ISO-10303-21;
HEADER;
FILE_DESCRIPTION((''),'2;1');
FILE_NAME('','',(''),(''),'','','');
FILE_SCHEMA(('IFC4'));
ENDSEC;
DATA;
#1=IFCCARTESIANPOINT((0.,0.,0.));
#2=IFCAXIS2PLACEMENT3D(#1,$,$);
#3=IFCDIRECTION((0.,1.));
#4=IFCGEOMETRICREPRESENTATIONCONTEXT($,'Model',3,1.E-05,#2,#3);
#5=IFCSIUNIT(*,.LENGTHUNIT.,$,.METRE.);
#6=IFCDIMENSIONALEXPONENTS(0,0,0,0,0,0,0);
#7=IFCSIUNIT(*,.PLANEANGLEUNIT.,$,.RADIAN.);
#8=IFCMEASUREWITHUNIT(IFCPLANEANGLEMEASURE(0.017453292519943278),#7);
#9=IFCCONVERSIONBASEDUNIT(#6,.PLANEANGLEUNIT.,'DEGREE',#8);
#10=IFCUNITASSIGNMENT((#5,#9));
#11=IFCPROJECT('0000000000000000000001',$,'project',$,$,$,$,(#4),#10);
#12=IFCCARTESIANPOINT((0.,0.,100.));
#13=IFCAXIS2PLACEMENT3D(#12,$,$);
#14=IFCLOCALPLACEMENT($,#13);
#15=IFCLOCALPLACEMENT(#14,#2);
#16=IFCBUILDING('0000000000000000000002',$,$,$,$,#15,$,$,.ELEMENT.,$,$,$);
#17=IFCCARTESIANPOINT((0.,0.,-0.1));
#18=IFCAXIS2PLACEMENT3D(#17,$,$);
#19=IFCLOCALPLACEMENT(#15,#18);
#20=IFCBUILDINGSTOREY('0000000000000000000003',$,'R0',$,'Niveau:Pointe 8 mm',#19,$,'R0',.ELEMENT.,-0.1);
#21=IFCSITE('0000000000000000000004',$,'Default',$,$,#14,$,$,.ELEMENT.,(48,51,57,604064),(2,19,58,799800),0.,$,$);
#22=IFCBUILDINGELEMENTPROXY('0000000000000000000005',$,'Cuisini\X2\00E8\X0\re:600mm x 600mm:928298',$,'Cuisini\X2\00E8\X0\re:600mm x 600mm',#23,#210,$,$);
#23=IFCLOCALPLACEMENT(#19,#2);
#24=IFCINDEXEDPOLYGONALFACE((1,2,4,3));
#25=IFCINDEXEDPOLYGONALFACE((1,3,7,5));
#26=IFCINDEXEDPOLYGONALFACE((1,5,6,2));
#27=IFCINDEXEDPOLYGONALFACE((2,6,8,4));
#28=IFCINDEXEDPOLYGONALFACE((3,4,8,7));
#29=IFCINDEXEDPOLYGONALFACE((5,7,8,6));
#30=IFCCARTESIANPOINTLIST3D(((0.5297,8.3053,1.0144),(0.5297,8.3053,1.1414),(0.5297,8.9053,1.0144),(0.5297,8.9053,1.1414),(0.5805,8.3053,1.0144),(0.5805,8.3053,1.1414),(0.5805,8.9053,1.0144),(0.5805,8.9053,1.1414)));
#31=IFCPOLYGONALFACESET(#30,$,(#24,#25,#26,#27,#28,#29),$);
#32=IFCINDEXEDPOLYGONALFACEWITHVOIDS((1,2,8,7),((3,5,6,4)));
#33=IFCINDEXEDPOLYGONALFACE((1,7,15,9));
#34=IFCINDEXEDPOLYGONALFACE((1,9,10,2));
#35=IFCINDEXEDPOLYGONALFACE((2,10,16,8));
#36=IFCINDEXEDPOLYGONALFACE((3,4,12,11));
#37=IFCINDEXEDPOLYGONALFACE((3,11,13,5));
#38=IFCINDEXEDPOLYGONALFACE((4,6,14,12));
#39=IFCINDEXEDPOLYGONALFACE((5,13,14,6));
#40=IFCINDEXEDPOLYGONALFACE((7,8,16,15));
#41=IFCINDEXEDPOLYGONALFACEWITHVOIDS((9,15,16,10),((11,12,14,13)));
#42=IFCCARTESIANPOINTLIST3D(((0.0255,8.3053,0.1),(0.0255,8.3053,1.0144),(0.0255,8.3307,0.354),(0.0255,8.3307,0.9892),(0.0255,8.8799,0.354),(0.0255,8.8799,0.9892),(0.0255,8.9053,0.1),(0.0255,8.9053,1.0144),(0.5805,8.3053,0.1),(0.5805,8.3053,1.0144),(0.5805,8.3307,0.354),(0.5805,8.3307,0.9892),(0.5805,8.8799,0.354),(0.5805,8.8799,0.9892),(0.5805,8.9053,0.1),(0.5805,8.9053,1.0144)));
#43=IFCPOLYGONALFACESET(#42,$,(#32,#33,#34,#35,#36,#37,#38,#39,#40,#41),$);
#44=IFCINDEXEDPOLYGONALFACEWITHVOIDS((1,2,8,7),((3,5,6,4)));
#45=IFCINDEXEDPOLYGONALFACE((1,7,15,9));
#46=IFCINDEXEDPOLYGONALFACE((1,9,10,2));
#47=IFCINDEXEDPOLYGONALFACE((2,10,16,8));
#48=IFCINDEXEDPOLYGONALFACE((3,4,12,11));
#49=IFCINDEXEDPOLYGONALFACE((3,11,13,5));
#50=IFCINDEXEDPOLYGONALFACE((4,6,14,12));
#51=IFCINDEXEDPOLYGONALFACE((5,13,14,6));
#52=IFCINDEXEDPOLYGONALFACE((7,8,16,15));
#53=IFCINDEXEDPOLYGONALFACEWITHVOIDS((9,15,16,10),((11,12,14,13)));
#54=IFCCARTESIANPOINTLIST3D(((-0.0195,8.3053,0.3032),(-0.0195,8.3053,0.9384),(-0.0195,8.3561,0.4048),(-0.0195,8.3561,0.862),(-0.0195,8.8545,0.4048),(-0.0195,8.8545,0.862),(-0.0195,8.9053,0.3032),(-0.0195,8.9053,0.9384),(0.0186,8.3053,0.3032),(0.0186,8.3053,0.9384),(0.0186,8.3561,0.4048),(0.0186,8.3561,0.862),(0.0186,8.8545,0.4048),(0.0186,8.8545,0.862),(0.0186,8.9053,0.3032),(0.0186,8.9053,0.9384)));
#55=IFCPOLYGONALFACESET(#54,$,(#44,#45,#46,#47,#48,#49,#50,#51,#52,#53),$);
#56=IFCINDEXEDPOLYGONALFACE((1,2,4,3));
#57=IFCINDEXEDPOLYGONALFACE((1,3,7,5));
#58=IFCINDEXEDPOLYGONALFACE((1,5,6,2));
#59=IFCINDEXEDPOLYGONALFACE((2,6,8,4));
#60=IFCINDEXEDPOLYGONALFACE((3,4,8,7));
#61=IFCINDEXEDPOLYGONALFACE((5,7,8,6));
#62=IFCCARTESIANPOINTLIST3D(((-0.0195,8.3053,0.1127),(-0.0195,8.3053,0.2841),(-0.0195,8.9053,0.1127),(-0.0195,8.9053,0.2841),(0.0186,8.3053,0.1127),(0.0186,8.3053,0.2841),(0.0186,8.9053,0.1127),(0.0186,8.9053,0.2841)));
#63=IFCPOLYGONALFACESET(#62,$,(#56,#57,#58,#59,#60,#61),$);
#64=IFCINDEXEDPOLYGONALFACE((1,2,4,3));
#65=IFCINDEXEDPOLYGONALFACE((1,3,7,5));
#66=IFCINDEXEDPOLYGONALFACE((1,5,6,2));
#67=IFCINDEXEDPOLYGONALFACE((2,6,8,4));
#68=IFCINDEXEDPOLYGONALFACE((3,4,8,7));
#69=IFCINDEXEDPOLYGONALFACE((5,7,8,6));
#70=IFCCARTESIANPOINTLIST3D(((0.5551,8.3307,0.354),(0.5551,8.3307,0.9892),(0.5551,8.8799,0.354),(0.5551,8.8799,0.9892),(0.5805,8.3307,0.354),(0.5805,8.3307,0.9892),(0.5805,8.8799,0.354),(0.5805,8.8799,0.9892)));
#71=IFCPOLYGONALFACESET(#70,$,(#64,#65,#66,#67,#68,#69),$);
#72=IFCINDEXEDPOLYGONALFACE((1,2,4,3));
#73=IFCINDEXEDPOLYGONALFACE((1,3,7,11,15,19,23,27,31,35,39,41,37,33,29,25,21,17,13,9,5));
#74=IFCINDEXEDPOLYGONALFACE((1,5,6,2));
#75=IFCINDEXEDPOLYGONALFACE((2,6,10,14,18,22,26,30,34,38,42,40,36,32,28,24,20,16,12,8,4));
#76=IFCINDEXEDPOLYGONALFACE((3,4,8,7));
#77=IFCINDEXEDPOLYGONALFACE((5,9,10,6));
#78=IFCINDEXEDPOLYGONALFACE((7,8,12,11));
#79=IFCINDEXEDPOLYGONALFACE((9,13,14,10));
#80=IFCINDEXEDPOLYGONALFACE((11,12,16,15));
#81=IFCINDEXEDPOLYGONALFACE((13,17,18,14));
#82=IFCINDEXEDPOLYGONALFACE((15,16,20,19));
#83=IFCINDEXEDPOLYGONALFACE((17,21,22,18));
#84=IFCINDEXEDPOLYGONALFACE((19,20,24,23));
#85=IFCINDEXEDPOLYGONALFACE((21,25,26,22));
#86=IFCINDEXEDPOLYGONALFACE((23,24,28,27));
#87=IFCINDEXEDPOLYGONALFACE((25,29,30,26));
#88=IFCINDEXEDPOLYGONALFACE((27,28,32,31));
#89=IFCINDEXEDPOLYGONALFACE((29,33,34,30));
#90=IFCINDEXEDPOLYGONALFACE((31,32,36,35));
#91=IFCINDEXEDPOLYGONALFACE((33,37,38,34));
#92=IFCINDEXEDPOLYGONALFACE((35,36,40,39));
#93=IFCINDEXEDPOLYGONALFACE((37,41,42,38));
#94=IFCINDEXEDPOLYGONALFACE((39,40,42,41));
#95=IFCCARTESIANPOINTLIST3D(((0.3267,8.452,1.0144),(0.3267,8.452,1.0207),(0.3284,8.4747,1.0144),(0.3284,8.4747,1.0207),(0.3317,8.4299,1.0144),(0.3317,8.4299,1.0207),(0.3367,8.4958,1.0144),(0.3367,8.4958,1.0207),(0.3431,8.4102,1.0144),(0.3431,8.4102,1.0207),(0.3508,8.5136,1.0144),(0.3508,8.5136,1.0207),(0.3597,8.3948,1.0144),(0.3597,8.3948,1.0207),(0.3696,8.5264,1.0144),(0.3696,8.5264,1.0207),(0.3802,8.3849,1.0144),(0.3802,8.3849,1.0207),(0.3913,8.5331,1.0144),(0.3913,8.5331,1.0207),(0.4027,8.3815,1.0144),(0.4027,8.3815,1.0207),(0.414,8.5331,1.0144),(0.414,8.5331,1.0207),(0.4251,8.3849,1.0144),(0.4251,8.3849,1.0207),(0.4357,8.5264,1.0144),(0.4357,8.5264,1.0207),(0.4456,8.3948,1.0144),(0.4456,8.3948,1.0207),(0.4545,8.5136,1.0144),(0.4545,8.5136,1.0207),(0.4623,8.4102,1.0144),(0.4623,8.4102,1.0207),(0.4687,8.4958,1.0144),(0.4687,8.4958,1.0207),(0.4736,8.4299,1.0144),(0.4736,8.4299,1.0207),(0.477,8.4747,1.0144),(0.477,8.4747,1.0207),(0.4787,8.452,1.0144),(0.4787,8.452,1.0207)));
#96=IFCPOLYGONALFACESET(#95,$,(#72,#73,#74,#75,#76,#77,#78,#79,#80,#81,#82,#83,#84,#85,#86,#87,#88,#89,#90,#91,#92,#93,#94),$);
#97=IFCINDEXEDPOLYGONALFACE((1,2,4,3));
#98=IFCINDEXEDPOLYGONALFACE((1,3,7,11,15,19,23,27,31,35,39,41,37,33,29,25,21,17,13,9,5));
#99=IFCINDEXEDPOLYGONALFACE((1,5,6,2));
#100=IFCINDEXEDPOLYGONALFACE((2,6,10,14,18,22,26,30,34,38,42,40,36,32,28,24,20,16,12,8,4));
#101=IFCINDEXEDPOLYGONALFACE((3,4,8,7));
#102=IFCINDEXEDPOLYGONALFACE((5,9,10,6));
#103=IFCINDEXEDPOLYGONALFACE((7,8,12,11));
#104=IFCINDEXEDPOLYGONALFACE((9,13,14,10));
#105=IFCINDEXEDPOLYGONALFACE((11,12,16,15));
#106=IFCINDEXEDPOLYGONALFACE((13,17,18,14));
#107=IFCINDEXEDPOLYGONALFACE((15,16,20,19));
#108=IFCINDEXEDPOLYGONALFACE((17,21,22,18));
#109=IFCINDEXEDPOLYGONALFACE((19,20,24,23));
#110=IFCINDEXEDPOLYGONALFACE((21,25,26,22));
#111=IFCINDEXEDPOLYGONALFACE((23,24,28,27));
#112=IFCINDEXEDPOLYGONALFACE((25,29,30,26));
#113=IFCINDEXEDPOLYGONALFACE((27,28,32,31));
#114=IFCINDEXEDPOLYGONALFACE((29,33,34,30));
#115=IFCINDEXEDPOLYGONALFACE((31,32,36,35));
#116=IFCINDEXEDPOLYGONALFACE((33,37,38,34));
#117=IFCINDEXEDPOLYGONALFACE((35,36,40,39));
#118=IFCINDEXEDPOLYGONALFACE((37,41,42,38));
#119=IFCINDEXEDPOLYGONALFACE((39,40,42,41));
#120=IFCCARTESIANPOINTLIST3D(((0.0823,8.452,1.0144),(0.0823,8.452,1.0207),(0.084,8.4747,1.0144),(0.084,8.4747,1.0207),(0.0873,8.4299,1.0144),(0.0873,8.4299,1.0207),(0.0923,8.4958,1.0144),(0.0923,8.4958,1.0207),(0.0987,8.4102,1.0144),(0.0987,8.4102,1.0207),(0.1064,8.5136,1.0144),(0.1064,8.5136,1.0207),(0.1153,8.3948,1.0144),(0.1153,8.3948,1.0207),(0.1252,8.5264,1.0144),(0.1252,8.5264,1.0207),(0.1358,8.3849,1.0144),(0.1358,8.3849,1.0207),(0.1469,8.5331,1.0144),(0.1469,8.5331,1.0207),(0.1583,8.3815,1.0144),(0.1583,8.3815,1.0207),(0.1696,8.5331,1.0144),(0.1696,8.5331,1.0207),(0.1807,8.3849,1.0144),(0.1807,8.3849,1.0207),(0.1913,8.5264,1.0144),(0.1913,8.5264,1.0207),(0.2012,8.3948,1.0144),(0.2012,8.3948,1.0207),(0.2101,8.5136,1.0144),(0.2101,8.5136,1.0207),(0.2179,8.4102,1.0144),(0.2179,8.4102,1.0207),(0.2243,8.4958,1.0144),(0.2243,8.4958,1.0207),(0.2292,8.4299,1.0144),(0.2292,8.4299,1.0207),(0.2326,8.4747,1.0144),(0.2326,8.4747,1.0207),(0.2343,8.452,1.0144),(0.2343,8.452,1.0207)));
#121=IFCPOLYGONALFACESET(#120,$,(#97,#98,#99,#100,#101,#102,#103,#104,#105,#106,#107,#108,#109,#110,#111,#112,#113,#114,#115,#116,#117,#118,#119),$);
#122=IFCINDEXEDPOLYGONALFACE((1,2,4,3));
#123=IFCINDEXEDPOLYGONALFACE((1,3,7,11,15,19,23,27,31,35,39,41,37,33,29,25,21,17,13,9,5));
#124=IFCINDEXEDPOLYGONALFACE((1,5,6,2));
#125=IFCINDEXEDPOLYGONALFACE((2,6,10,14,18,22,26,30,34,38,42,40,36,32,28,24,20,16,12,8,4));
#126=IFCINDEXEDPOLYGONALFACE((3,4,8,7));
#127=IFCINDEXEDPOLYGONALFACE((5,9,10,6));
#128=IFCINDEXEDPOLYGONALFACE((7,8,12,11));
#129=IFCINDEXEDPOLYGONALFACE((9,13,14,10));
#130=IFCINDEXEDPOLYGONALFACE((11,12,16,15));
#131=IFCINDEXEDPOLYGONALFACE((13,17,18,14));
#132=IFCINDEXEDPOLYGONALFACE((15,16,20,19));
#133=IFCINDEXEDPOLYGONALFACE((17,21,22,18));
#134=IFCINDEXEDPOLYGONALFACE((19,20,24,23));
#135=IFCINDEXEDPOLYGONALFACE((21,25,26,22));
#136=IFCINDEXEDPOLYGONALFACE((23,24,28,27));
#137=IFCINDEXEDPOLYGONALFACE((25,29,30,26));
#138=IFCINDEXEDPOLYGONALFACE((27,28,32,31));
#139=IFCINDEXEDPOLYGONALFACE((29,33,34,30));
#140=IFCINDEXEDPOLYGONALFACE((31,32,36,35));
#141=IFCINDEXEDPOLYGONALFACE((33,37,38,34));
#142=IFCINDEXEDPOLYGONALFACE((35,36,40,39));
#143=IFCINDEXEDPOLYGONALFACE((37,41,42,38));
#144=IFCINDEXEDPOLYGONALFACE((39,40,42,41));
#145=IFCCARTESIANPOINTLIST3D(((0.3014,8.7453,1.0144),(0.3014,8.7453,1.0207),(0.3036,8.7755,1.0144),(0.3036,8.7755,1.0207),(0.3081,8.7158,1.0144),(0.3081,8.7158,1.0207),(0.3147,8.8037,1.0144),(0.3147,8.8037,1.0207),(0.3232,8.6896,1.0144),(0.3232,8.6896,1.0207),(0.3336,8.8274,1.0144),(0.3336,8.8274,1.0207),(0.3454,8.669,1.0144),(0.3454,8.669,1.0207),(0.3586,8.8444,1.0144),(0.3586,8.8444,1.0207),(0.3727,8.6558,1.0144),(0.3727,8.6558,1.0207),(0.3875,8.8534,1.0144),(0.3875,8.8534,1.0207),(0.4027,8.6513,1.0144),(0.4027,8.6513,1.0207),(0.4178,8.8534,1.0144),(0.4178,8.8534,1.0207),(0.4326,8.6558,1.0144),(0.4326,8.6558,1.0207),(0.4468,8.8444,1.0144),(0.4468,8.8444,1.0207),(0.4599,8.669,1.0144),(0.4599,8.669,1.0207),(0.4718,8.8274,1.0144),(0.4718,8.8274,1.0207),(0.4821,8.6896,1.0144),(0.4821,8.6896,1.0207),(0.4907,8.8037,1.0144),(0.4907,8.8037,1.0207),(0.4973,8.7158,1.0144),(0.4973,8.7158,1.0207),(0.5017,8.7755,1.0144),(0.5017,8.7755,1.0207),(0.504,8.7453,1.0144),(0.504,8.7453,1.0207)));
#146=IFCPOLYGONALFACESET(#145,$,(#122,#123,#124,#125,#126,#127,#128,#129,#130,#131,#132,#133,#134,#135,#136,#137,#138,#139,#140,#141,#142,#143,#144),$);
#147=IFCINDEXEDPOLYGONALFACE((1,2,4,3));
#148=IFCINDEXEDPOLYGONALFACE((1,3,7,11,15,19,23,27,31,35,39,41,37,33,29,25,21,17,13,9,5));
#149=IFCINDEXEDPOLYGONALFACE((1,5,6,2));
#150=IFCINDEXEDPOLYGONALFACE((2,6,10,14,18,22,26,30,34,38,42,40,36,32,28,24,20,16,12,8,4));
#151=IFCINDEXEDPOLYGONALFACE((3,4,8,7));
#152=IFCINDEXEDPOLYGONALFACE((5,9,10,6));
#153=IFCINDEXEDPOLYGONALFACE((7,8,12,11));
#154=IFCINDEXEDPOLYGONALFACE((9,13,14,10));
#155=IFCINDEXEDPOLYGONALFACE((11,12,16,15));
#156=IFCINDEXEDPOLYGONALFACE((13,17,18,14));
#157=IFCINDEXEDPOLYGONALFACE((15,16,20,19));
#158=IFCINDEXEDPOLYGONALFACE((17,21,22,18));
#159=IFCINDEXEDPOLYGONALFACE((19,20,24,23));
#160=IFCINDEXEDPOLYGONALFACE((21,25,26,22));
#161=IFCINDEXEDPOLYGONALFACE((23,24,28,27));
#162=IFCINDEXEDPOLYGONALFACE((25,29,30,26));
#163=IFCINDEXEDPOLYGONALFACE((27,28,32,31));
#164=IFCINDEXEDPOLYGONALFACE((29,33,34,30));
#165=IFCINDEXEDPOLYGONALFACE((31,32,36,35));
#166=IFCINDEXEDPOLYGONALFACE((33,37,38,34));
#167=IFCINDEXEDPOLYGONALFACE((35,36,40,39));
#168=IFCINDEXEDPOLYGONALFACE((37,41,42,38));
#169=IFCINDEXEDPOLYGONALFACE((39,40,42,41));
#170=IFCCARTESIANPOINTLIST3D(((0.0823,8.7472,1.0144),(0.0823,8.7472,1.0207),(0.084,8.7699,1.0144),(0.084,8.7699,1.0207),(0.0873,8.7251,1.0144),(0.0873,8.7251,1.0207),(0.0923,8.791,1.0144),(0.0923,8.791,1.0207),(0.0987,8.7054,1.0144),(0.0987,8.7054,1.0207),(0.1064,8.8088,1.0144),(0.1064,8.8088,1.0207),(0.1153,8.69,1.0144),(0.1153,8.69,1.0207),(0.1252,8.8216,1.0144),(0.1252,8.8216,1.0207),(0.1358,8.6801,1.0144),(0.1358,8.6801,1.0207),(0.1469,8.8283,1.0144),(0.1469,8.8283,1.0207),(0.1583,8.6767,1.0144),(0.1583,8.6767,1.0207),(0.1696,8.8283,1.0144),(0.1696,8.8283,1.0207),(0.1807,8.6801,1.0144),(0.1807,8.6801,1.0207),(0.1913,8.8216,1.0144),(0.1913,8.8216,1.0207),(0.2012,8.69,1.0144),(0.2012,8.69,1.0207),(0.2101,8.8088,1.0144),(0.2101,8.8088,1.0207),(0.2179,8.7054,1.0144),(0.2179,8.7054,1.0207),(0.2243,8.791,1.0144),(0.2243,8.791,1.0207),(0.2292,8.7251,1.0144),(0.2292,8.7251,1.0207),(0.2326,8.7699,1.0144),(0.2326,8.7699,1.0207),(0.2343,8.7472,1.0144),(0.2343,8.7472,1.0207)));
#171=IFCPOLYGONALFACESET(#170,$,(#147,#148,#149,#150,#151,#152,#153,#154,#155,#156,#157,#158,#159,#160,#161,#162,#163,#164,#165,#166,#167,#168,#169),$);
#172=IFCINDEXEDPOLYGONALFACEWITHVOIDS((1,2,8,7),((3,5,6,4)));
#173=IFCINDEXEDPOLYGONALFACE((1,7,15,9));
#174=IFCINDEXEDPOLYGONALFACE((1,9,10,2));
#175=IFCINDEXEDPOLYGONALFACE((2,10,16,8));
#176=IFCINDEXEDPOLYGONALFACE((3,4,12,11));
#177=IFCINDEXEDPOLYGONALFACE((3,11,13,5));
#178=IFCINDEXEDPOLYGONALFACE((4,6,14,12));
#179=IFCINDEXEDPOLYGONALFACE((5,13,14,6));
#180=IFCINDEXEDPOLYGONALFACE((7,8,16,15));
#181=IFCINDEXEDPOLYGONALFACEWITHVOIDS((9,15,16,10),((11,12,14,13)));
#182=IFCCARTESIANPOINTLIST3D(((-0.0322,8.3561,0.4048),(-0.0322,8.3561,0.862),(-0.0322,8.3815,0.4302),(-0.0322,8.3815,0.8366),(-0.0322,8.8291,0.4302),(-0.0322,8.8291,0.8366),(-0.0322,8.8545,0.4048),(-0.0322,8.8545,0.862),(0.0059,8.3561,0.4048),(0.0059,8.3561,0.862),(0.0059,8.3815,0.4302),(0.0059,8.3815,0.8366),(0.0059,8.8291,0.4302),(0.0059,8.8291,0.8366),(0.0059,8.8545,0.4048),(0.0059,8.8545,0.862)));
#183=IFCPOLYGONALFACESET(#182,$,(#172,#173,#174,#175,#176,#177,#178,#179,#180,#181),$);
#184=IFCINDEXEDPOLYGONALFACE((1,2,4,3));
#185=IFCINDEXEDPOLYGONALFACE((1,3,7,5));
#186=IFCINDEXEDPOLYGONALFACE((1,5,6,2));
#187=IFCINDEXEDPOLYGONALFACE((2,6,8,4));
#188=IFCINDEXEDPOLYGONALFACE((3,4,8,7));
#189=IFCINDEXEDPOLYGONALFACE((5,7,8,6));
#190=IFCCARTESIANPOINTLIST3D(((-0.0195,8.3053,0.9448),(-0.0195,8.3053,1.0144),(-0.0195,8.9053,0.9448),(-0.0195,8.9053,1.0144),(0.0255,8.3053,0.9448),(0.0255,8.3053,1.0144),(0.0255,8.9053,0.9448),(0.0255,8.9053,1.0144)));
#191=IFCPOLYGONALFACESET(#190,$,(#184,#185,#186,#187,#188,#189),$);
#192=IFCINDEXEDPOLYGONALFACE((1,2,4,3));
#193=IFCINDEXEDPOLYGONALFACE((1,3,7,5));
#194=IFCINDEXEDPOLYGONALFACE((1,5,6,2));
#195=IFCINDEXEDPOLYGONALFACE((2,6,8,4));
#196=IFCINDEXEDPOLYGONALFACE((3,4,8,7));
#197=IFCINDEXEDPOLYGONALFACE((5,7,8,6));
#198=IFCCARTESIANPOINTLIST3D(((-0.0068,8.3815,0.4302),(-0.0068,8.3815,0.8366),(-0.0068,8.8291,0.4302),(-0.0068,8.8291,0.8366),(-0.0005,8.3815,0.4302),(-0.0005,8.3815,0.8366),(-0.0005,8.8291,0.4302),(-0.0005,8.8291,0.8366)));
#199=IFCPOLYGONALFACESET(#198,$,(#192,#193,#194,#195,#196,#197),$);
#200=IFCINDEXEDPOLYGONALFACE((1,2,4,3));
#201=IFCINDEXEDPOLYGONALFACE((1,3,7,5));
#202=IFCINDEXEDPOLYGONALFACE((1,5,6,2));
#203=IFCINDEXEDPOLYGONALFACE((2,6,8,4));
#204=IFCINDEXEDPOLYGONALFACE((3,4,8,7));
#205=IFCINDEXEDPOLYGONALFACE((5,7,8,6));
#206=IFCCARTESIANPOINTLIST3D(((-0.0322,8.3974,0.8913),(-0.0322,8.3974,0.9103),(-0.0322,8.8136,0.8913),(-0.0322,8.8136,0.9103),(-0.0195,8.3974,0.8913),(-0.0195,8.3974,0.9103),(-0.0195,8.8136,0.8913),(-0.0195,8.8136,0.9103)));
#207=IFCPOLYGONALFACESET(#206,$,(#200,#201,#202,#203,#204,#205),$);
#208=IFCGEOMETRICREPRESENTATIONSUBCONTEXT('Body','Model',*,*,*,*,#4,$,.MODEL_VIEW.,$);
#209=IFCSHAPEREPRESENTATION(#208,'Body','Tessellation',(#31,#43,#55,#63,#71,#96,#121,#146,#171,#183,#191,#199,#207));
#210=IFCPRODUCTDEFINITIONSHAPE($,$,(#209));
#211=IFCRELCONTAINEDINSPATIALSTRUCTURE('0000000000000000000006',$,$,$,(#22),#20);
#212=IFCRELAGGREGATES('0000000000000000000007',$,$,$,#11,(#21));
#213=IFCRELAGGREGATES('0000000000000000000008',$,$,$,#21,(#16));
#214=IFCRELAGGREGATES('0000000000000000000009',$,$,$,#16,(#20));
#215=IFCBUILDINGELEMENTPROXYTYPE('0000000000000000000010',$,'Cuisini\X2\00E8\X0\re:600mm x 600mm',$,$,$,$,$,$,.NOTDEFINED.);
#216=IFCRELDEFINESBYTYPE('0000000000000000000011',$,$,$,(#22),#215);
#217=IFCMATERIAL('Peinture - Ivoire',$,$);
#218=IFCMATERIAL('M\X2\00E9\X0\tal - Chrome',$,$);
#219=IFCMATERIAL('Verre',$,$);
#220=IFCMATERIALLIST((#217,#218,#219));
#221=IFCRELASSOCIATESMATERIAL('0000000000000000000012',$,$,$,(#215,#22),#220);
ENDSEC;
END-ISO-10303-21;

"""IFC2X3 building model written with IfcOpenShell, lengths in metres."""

from ifc_helpers import new_model, entity, si_unit, converted_unit, direction, frame, frame_2d, origin, origin_2d_with_axis, place, context, subcontext, project, spatial, polyline, rectangle, circle, outline, extrude, source, transform, mapped, material, material_list, type_object, type_shapes, element, save


model = new_model("IFC2X3")

# Units and contexts
model_context = context("Model", 3, precision=1e-05, world=origin(), true_north=direction((0.0, 1.0)))
body_context = subcontext(model_context, "Body", "Model", "MODEL_VIEW")
ifc_project = project(units=[si_unit("LENGTHUNIT", "METRE"), converted_unit("PLANEANGLEUNIT", "DEGREE", entity("IfcPlaneAngleMeasure", 0.017453292519943278), si_unit("PLANEANGLEUNIT", "RADIAN"), dimensions=[0, 0, 0, 0, 0, 0, 0])], contexts=[model_context])

# Site, building, storey
site_placement = place(None, frame((0.0, 0.0, 100.0)))
site = spatial("IfcSite", under=ifc_project, at=site_placement, Name="Default", CompositionType="ELEMENT", RefLatitude=(48, 51, 57, 604064), RefLongitude=(2, 19, 58, 799800), RefElevation=0.0)
building_placement = place(site_placement, origin())
building = spatial("IfcBuilding", under=site, at=building_placement, CompositionType="ELEMENT")
storey_placement = place(building_placement, frame((0.0, 0.0, -0.1)))
storey = spatial("IfcBuildingStorey", under=building, at=storey_placement, Name="R0", ObjectType="Niveau:Pointe 8 mm", LongName="R0", CompositionType="ELEMENT", Elevation=-0.1)

# Building element proxy
ifc_material_1 = material(Name="Peinture - Ivoire")
ifc_material_2 = material(Name="Métal - Chrome")
ifc_material_3 = material(Name="Verre")
ifc_material_list_1 = material_list([ifc_material_1, ifc_material_2, ifc_material_3])
building_element_proxy_type = type_object("IfcBuildingElementProxyType", Name="Cuisinière:600mm x 600mm", PredefinedType="NOTDEFINED", material=ifc_material_list_1)
shared_shape_1 = source(origin(), body_context, "Body", "SweptSolid", [
    extrude(rectangle(XDim=0.6, YDim=0.0508, at=origin_2d_with_axis()), frame((0.3, 0.5746, 0.9144), z_axis=(0.0, 0.0, 1.0), x_axis=(-1.0, 0.0, 0.0)), (0.0, 0.0, 1.0), 0.127),
    extrude(outline(polyline([(-0.4572, -0.3), (0.4572, -0.3), (0.4572, 0.3), (-0.4572, 0.3), (-0.4572, -0.3)]), holes=[polyline([(-0.432, -0.2746), (-0.432, 0.2746), (0.2032, 0.2746), (0.2032, -0.2746), (-0.432, -0.2746)])]), frame((0.3, 0.045, 0.4572), z_axis=(0.0, 1.0, 0.0), x_axis=(0.0, 0.0, -1.0)), (0.0, 0.0, 1.0), 0.555),
    extrude(outline(polyline([(-0.3176, -0.3), (0.3176, -0.3), (0.3176, 0.3), (-0.3176, 0.3), (-0.3176, -0.3)]), holes=[polyline([(-0.2412, -0.2492), (-0.2412, 0.2492), (0.216, 0.2492), (0.216, -0.2492), (-0.2412, -0.2492)])]), frame((0.3, 0.0, 0.5208), z_axis=(0.0, 1.0, 0.0), x_axis=(0.0, 0.0, -1.0)), (0.0, 0.0, 1.0), 0.0381),
    extrude(rectangle(XDim=0.0381, YDim=0.6, at=origin_2d_with_axis()), frame((0.3, 0.0191, 0.0127), z_axis=(0.0, 0.0, 1.0), x_axis=(0.0, 1.0, 0.0)), (0.0, 0.0, 1.0), 0.1715),
    extrude(rectangle(XDim=0.0254, YDim=0.5492, at=frame_2d((0.0, 0.0), x_axis=(1.0, 0.0))), frame((0.3, 0.5873, 0.254), z_axis=(0.0, 0.0, 1.0), x_axis=(0.0, -1.0, 0.0)), (0.0, 0.0, 1.0), 0.6352),
    extrude(circle(Radius=0.0762, at=frame_2d((0.0, 0.0), x_axis=(1.0, 0.0))), frame((0.4476, 0.4222, 0.9144)), (0.0, 0.0, 1.0), 0.0064),
    extrude(circle(Radius=0.0762, at=frame_2d((0.0, 0.0), x_axis=(1.0, 0.0))), frame((0.4476, 0.1778, 0.9144)), (0.0, 0.0, 1.0), 0.0064),
    extrude(circle(Radius=0.1016, at=frame_2d((0.0, 0.0), x_axis=(1.0, 0.0))), frame((0.1524, 0.4222, 0.9144)), (0.0, 0.0, 1.0), 0.0064),
    extrude(circle(Radius=0.0762, at=frame_2d((0.0, 0.0), x_axis=(1.0, 0.0))), frame((0.1524, 0.1778, 0.9144)), (0.0, 0.0, 1.0), 0.0064),
    extrude(outline(polyline([(-0.2286, -0.2492), (0.2286, -0.2492), (0.2286, 0.2492), (-0.2286, 0.2492), (-0.2286, -0.2492)]), holes=[polyline([(-0.2032, -0.2238), (-0.2032, 0.2238), (0.2032, 0.2238), (0.2032, -0.2238), (-0.2032, -0.2238)])]), frame((0.3, -0.0127, 0.5334), z_axis=(0.0, 1.0, 0.0), x_axis=(0.0, 0.0, -1.0)), (0.0, 0.0, 1.0), 0.0381),
    extrude(rectangle(XDim=0.045, YDim=0.6, at=origin_2d_with_axis()), frame((0.3, 0.0225, 0.8448), z_axis=(0.0, 0.0, 1.0), x_axis=(0.0, 1.0, 0.0)), (0.0, 0.0, 1.0), 0.0696),
    extrude(rectangle(XDim=0.0064, YDim=0.4476, at=frame_2d((0.0, 0.0), x_axis=(1.0, 0.0))), frame((0.3, 0.0159, 0.3302), z_axis=(0.0, 0.0, 1.0), x_axis=(0.0, 1.0, 0.0)), (0.0, 0.0, 1.0), 0.4064),
    extrude(rectangle(XDim=0.0127, YDim=0.4162, at=origin_2d_with_axis()), frame((0.2998, -0.0063, 0.7913), z_axis=(0.0, 0.0, 1.0), x_axis=(0.0, 1.0, 0.0)), (0.0, 0.0, 1.0), 0.019),
])
type_shapes(building_element_proxy_type, [shared_shape_1])
proxy_placement = place(storey_placement, frame((-0.0195, 8.9053, 0.1), z_axis=(0.0, 0.0, 1.0), x_axis=(0.0, -1.0, 0.0)))
element("IfcBuildingElementProxy", 1, at=proxy_placement, inside=storey, type_object=building_element_proxy_type, material=ifc_material_list_1, Name="Cuisinière:600mm x 600mm:928298", ObjectType="Cuisinière:600mm x 600mm", context=body_context, shape_type="MappedRepresentation", body=[
    mapped(shared_shape_1, transform((0.0, 0.0, 0.0), scale=1.0)),
])

save(model, "model.ifc")
